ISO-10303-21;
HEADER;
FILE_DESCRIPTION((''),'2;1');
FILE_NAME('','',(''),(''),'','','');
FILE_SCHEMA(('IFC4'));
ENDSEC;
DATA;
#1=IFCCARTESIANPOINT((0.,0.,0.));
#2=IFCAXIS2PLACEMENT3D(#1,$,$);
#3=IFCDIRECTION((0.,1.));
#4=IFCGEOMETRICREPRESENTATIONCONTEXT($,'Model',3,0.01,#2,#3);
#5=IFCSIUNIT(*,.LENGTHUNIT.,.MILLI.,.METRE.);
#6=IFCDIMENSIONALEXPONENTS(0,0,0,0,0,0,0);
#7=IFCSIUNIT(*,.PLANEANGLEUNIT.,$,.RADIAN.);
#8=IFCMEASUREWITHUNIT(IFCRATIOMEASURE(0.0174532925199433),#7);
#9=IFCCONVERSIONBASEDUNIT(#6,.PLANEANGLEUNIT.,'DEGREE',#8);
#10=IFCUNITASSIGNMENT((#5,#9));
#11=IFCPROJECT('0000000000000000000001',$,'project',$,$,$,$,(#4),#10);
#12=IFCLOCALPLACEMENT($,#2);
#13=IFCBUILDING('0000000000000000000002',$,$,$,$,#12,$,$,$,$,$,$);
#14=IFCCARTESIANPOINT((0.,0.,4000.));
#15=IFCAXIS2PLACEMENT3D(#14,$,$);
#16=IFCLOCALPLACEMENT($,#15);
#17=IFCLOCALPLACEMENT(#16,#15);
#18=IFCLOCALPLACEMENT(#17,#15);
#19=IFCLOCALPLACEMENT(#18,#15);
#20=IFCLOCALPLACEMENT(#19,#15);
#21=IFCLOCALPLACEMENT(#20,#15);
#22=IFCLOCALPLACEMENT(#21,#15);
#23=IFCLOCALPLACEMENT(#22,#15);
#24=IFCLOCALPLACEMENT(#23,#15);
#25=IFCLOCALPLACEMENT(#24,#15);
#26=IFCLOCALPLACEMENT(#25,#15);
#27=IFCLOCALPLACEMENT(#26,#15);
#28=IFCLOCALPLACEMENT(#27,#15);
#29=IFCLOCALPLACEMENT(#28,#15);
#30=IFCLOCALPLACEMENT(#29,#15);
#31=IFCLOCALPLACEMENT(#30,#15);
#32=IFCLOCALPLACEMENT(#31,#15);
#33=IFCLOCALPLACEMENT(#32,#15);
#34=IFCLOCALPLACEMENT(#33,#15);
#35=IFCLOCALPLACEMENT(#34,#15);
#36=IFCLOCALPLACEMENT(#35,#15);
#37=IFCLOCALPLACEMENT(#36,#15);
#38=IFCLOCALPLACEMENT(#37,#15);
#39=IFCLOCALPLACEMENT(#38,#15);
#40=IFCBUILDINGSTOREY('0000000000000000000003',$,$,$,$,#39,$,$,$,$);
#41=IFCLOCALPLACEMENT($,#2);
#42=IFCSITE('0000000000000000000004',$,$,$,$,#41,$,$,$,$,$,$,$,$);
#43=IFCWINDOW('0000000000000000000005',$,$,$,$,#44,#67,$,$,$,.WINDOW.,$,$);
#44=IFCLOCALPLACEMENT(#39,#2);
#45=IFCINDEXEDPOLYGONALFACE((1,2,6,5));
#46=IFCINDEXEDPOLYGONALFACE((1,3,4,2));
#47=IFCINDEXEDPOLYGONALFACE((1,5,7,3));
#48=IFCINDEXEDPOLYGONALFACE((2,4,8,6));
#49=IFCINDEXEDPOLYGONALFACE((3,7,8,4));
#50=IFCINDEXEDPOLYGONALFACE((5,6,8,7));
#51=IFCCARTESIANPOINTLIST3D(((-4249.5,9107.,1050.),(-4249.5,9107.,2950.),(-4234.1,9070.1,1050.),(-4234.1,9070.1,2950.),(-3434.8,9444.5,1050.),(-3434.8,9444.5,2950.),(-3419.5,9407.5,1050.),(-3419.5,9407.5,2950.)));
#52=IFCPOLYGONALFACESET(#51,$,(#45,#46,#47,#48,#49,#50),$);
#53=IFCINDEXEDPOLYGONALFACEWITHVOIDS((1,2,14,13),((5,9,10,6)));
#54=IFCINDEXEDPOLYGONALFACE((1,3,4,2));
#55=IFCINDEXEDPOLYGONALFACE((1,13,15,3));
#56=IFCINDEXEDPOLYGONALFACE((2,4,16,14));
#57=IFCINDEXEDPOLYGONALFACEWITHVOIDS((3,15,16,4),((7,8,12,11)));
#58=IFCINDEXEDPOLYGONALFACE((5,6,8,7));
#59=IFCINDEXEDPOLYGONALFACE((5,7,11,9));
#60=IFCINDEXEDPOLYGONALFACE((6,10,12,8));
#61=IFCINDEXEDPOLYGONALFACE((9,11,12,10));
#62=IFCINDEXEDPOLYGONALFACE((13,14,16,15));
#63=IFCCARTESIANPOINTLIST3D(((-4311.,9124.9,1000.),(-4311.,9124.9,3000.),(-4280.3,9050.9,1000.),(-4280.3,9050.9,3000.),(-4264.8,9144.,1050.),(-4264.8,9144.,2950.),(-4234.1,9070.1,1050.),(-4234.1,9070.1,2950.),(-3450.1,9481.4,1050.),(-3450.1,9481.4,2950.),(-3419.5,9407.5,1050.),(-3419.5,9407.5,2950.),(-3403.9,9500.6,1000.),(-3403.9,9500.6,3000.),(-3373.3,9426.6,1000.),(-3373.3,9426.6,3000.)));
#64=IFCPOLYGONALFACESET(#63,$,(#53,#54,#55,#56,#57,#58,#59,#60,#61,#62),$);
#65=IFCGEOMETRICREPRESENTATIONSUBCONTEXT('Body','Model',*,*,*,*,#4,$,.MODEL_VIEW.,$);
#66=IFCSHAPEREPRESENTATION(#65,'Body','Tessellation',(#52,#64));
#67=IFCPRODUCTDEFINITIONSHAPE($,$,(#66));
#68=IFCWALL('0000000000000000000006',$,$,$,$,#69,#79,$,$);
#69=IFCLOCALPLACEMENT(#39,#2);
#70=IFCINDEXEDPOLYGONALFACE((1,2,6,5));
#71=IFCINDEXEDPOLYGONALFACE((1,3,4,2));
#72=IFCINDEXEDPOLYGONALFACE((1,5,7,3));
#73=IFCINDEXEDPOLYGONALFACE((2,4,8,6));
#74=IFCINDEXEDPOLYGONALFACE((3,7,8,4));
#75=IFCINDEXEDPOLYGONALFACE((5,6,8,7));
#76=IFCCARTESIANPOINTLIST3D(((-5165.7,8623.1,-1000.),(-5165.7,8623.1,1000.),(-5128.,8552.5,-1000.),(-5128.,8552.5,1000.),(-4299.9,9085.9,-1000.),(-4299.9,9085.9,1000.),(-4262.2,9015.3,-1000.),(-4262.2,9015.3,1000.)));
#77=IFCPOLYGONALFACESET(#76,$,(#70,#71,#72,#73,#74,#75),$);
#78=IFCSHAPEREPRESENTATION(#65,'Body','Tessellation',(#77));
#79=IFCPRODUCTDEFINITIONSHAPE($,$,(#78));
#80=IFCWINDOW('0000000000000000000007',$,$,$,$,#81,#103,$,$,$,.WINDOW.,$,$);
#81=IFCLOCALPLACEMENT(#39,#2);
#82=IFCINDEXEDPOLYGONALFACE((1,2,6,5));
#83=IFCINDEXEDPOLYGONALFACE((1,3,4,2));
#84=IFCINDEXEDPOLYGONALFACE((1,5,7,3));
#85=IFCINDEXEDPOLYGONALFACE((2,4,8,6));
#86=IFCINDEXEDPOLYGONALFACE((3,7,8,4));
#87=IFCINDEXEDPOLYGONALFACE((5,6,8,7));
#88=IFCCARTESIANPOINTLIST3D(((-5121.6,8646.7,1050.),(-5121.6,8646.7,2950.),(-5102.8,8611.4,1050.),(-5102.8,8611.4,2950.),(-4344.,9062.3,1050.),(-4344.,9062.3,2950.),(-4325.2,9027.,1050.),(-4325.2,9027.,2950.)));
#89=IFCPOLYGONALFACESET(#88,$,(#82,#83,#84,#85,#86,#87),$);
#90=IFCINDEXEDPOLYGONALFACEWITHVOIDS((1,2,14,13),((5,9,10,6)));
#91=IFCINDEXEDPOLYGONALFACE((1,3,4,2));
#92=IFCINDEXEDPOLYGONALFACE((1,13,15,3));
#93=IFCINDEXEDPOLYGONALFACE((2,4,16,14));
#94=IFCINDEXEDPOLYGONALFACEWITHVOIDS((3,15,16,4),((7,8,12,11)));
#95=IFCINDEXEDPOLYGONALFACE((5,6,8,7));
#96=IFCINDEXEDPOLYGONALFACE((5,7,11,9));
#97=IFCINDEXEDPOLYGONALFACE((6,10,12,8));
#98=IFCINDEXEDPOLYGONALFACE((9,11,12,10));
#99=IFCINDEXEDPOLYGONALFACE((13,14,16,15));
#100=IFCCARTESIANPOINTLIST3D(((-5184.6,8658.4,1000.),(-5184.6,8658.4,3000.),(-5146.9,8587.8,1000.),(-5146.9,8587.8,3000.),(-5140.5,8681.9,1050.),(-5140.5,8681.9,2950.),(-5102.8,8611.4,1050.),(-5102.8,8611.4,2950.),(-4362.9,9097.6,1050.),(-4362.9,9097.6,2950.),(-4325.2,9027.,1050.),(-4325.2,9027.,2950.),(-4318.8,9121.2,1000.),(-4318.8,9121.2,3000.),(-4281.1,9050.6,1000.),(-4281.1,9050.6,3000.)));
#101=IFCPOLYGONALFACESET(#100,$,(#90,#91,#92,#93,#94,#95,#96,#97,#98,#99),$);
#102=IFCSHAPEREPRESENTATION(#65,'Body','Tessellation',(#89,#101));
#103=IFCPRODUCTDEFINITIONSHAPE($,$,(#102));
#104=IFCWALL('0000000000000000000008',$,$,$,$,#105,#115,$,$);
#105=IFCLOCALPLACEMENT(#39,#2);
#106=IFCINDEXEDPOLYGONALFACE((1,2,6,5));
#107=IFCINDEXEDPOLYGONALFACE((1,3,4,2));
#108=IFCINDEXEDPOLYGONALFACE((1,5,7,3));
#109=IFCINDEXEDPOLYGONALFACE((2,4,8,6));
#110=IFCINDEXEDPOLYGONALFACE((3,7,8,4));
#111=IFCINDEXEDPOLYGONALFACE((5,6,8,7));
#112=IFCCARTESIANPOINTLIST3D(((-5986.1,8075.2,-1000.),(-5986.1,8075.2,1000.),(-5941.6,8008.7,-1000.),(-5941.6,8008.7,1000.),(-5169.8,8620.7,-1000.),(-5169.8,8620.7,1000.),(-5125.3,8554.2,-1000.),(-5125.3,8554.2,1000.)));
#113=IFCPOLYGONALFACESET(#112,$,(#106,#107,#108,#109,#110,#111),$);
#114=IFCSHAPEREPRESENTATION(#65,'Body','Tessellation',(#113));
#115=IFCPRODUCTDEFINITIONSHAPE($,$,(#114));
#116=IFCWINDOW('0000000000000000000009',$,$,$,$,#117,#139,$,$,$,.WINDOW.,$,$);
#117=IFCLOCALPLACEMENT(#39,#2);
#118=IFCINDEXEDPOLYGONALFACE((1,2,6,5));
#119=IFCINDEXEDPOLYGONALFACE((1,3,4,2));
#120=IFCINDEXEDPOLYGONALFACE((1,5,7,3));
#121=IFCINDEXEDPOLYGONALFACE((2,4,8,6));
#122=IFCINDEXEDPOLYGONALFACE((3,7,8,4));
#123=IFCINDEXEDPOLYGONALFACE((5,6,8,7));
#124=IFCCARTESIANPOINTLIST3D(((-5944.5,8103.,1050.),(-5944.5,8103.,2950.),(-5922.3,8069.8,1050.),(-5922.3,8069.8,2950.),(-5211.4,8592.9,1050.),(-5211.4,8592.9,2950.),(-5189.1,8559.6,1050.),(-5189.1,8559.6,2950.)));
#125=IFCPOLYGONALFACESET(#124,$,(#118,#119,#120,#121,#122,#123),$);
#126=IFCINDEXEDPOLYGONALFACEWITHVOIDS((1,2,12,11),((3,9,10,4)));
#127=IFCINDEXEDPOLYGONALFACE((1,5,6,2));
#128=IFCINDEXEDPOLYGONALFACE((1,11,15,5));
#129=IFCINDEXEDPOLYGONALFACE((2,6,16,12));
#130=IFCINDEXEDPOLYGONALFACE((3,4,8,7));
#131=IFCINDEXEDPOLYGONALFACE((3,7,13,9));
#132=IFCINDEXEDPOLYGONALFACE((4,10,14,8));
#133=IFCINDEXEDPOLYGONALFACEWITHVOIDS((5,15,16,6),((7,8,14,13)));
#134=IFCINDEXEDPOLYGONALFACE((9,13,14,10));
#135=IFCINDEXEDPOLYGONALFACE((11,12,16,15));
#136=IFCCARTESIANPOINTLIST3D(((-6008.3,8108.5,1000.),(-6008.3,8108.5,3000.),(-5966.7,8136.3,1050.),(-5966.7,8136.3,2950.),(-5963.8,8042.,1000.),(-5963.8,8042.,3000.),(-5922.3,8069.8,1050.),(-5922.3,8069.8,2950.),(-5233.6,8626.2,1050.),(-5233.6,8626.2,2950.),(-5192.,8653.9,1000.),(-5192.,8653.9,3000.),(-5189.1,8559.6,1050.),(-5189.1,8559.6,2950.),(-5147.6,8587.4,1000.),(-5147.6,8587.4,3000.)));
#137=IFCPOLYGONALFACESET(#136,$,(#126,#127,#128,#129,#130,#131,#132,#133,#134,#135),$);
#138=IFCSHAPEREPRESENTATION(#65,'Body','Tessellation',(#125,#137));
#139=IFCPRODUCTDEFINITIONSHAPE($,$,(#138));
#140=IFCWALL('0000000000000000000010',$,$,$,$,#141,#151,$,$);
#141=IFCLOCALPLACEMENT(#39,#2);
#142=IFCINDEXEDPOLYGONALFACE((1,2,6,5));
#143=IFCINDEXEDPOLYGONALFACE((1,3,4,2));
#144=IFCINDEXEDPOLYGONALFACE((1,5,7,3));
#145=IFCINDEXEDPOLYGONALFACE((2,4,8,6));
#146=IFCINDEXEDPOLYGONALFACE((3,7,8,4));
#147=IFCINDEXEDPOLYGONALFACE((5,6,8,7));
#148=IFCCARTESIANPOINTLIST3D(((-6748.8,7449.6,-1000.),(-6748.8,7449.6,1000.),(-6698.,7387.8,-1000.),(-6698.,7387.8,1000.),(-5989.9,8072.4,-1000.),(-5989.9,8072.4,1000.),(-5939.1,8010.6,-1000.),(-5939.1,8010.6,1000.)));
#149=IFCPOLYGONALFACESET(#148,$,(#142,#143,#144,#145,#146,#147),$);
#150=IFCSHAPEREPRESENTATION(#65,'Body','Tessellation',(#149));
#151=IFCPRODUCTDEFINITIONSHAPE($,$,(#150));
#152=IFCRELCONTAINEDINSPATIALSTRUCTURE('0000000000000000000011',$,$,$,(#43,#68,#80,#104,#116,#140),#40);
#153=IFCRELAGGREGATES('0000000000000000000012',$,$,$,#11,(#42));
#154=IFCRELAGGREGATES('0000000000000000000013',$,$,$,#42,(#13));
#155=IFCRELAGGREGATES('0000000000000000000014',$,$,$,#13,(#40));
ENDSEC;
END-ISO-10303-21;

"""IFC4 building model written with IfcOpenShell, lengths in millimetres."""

from ifc_helpers import new_model, entity, si_unit, converted_unit, direction, frame, origin, origin_2d, place, context, subcontext, project, spatial, rectangle, extrude, element, save


model = new_model("IFC4")

# Units and contexts
model_context = context("Model", 3, precision=0.01, world=origin(), true_north=direction((0.0, 1.0)))
body_context = subcontext(model_context, "Body", "Model", "MODEL_VIEW")
ifc_project = project(units=[si_unit("LENGTHUNIT", "METRE", prefix="MILLI"), converted_unit("PLANEANGLEUNIT", "DEGREE", entity("IfcRatioMeasure", 0.0174532925199433), si_unit("PLANEANGLEUNIT", "RADIAN"), dimensions=[0, 0, 0, 0, 0, 0, 0])], contexts=[model_context])

# Site, building, storey
site_placement = place(None, origin())
site = spatial("IfcSite", under=ifc_project, at=site_placement)
building_placement = place(None, origin())
building = spatial("IfcBuilding", under=site, at=building_placement)
placement_1 = place(None, frame((0.0, 0.0, 4000.0)))
placement_2 = place(placement_1, frame((0.0, 0.0, 4000.0)))
placement_3 = place(placement_2, frame((0.0, 0.0, 4000.0)))
placement_4 = place(placement_3, frame((0.0, 0.0, 4000.0)))
placement_5 = place(placement_4, frame((0.0, 0.0, 4000.0)))
placement_6 = place(placement_5, frame((0.0, 0.0, 4000.0)))
placement_7 = place(placement_6, frame((0.0, 0.0, 4000.0)))
placement_8 = place(placement_7, frame((0.0, 0.0, 4000.0)))
placement_9 = place(placement_8, frame((0.0, 0.0, 4000.0)))
placement_10 = place(placement_9, frame((0.0, 0.0, 4000.0)))
placement_11 = place(placement_10, frame((0.0, 0.0, 4000.0)))
placement_12 = place(placement_11, frame((0.0, 0.0, 4000.0)))
placement_13 = place(placement_12, frame((0.0, 0.0, 4000.0)))
placement_14 = place(placement_13, frame((0.0, 0.0, 4000.0)))
placement_15 = place(placement_14, frame((0.0, 0.0, 4000.0)))
placement_16 = place(placement_15, frame((0.0, 0.0, 4000.0)))
placement_17 = place(placement_16, frame((0.0, 0.0, 4000.0)))
placement_18 = place(placement_17, frame((0.0, 0.0, 4000.0)))
placement_19 = place(placement_18, frame((0.0, 0.0, 4000.0)))
placement_20 = place(placement_19, frame((0.0, 0.0, 4000.0)))
placement_21 = place(placement_20, frame((0.0, 0.0, 4000.0)))
placement_22 = place(placement_21, frame((0.0, 0.0, 4000.0)))
placement_23 = place(placement_22, frame((0.0, 0.0, 4000.0)))
storey_placement = place(placement_23, frame((0.0, 0.0, 4000.0)))
storey = spatial("IfcBuildingStorey", under=building, at=storey_placement)

# Shared definitions
cartesian_point_1 = entity("IfcCartesianPoint", [-440.9, -950.0])
shared_polyline = entity("IfcPolyline", [cartesian_point_1, entity("IfcCartesianPoint", [-440.9, 950.0]), entity("IfcCartesianPoint", [-440.9, 950.0]), entity("IfcCartesianPoint", [440.9, 950.0]), entity("IfcCartesianPoint", [440.9, 950.0]), entity("IfcCartesianPoint", [440.9, -950.0]), entity("IfcCartesianPoint", [440.9, -950.0]), entity("IfcCartesianPoint", [-440.9, -950.0]), cartesian_point_1])

# Window
window_1_placement = place(storey_placement, frame((-3826.8, 9238.8, 2000.0), z_axis=(0.0, 0.0, 1.0), x_axis=(-9238.795458, -3826.834002, 0.0)))
cartesian_point_2 = entity("IfcCartesianPoint", [-490.9, -1000.0])
element("IfcWindow", 1, at=window_1_placement, inside=storey, PredefinedType="WINDOW", context=body_context, shape_type="SweptSolid", body=[
    entity("IfcExtrudedAreaSolid", entity("IfcArbitraryClosedProfileDef", "AREA", None, shared_polyline), entity("IfcAxis2Placement3D", entity("IfcCartesianPoint", [0.0, 0.0, 0.0]), entity("IfcDirection", [0.0, -1.0, 0.0]), entity("IfcDirection", [1.0, 0.0, 0.0])), entity("IfcDirection", [0.0, 0.0, 1.0]), 40.0),
    entity("IfcExtrudedAreaSolid", entity("IfcArbitraryProfileDefWithVoids", "AREA", None, entity("IfcPolyline", [cartesian_point_2, entity("IfcCartesianPoint", [-490.9, 1000.0]), entity("IfcCartesianPoint", [-490.9, 1000.0]), entity("IfcCartesianPoint", [490.9, 1000.0]), entity("IfcCartesianPoint", [490.9, 1000.0]), entity("IfcCartesianPoint", [490.9, -1000.0]), entity("IfcCartesianPoint", [490.9, -1000.0]), entity("IfcCartesianPoint", [-490.9, -1000.0]), cartesian_point_2]), [shared_polyline]), entity("IfcAxis2Placement3D", entity("IfcCartesianPoint", [0.0, 0.0, 0.0]), entity("IfcDirection", [0.0, -1.0, 0.0]), entity("IfcDirection", [1.0, 0.0, 0.0])), entity("IfcDirection", [0.0, 0.0, 1.0]), 80.0),
])

# Wall
wall_1_placement = place(storey_placement, frame((-4714.0, 8819.2, -1000.0), z_axis=(0.0, 0.0, 1.0), x_axis=(-8819.213181, -4713.966363, 0.0)))
element("IfcWall", 2, at=wall_1_placement, inside=storey, context=body_context, shape_type="SweptSolid", body=[
    extrude(rectangle(XDim=981.7, YDim=80.0, at=origin_2d()), origin(), (0.0, 0.0, 1.0), 2000.0),
])

# Window
window_2_placement = place(storey_placement, frame((-4714.0, 8819.2, 2000.0), z_axis=(0.0, 0.0, 1.0), x_axis=(-8819.213181, -4713.966363, 0.0)))
cartesian_point_3 = entity("IfcCartesianPoint", [-490.9, -1000.0])
element("IfcWindow", 3, at=window_2_placement, inside=storey, PredefinedType="WINDOW", context=body_context, shape_type="SweptSolid", body=[
    entity("IfcExtrudedAreaSolid", entity("IfcArbitraryClosedProfileDef", "AREA", None, shared_polyline), entity("IfcAxis2Placement3D", entity("IfcCartesianPoint", [0.0, 0.0, 0.0]), entity("IfcDirection", [0.0, -1.0, 0.0]), entity("IfcDirection", [1.0, 0.0, 0.0])), entity("IfcDirection", [0.0, 0.0, 1.0]), 40.0),
    entity("IfcExtrudedAreaSolid", entity("IfcArbitraryProfileDefWithVoids", "AREA", None, entity("IfcPolyline", [cartesian_point_3, entity("IfcCartesianPoint", [-490.9, 1000.0]), entity("IfcCartesianPoint", [-490.9, 1000.0]), entity("IfcCartesianPoint", [490.9, 1000.0]), entity("IfcCartesianPoint", [490.9, 1000.0]), entity("IfcCartesianPoint", [490.9, -1000.0]), entity("IfcCartesianPoint", [490.9, -1000.0]), entity("IfcCartesianPoint", [-490.9, -1000.0]), cartesian_point_3]), [shared_polyline]), entity("IfcAxis2Placement3D", entity("IfcCartesianPoint", [0.0, 0.0, 0.0]), entity("IfcDirection", [0.0, -1.0, 0.0]), entity("IfcDirection", [1.0, 0.0, 0.0])), entity("IfcDirection", [0.0, 0.0, 1.0]), 80.0),
])

# Wall
wall_2_placement = place(storey_placement, frame((-5555.7, 8314.7, -1000.0), z_axis=(0.0, 0.0, 1.0), x_axis=(-8314.696534, -5555.701715, 0.0)))
element("IfcWall", 4, at=wall_2_placement, inside=storey, context=body_context, shape_type="SweptSolid", body=[
    extrude(rectangle(XDim=981.7, YDim=80.0, at=origin_2d()), origin(), (0.0, 0.0, 1.0), 2000.0),
])

# Window
window_3_placement = place(storey_placement, frame((-5555.7, 8314.7, 2000.0), z_axis=(0.0, 0.0, 1.0), x_axis=(-8314.696534, -5555.701715, 0.0)))
cartesian_point_4 = entity("IfcCartesianPoint", [-490.9, -1000.0])
element("IfcWindow", 5, at=window_3_placement, inside=storey, PredefinedType="WINDOW", context=body_context, shape_type="SweptSolid", body=[
    entity("IfcExtrudedAreaSolid", entity("IfcArbitraryClosedProfileDef", "AREA", None, shared_polyline), entity("IfcAxis2Placement3D", entity("IfcCartesianPoint", [0.0, 0.0, 0.0]), entity("IfcDirection", [0.0, -1.0, 0.0]), entity("IfcDirection", [1.0, 0.0, 0.0])), entity("IfcDirection", [0.0, 0.0, 1.0]), 40.0),
    entity("IfcExtrudedAreaSolid", entity("IfcArbitraryProfileDefWithVoids", "AREA", None, entity("IfcPolyline", [cartesian_point_4, entity("IfcCartesianPoint", [-490.9, 1000.0]), entity("IfcCartesianPoint", [-490.9, 1000.0]), entity("IfcCartesianPoint", [490.9, 1000.0]), entity("IfcCartesianPoint", [490.9, 1000.0]), entity("IfcCartesianPoint", [490.9, -1000.0]), entity("IfcCartesianPoint", [490.9, -1000.0]), entity("IfcCartesianPoint", [-490.9, -1000.0]), cartesian_point_4]), [shared_polyline]), entity("IfcAxis2Placement3D", entity("IfcCartesianPoint", [0.0, 0.0, 0.0]), entity("IfcDirection", [0.0, -1.0, 0.0]), entity("IfcDirection", [1.0, 0.0, 0.0])), entity("IfcDirection", [0.0, 0.0, 1.0]), 80.0),
])

# Wall
wall_3_placement = place(storey_placement, frame((-6343.9, 7730.1, -1000.0), z_axis=(0.0, 0.0, 1.0), x_axis=(-7730.104749, -6343.932579, 0.0)))
element("IfcWall", 6, at=wall_3_placement, inside=storey, context=body_context, shape_type="SweptSolid", body=[
    extrude(rectangle(XDim=981.7, YDim=80.0, at=origin_2d()), origin(), (0.0, 0.0, 1.0), 2000.0),
])

save(model, "model.ifc")
